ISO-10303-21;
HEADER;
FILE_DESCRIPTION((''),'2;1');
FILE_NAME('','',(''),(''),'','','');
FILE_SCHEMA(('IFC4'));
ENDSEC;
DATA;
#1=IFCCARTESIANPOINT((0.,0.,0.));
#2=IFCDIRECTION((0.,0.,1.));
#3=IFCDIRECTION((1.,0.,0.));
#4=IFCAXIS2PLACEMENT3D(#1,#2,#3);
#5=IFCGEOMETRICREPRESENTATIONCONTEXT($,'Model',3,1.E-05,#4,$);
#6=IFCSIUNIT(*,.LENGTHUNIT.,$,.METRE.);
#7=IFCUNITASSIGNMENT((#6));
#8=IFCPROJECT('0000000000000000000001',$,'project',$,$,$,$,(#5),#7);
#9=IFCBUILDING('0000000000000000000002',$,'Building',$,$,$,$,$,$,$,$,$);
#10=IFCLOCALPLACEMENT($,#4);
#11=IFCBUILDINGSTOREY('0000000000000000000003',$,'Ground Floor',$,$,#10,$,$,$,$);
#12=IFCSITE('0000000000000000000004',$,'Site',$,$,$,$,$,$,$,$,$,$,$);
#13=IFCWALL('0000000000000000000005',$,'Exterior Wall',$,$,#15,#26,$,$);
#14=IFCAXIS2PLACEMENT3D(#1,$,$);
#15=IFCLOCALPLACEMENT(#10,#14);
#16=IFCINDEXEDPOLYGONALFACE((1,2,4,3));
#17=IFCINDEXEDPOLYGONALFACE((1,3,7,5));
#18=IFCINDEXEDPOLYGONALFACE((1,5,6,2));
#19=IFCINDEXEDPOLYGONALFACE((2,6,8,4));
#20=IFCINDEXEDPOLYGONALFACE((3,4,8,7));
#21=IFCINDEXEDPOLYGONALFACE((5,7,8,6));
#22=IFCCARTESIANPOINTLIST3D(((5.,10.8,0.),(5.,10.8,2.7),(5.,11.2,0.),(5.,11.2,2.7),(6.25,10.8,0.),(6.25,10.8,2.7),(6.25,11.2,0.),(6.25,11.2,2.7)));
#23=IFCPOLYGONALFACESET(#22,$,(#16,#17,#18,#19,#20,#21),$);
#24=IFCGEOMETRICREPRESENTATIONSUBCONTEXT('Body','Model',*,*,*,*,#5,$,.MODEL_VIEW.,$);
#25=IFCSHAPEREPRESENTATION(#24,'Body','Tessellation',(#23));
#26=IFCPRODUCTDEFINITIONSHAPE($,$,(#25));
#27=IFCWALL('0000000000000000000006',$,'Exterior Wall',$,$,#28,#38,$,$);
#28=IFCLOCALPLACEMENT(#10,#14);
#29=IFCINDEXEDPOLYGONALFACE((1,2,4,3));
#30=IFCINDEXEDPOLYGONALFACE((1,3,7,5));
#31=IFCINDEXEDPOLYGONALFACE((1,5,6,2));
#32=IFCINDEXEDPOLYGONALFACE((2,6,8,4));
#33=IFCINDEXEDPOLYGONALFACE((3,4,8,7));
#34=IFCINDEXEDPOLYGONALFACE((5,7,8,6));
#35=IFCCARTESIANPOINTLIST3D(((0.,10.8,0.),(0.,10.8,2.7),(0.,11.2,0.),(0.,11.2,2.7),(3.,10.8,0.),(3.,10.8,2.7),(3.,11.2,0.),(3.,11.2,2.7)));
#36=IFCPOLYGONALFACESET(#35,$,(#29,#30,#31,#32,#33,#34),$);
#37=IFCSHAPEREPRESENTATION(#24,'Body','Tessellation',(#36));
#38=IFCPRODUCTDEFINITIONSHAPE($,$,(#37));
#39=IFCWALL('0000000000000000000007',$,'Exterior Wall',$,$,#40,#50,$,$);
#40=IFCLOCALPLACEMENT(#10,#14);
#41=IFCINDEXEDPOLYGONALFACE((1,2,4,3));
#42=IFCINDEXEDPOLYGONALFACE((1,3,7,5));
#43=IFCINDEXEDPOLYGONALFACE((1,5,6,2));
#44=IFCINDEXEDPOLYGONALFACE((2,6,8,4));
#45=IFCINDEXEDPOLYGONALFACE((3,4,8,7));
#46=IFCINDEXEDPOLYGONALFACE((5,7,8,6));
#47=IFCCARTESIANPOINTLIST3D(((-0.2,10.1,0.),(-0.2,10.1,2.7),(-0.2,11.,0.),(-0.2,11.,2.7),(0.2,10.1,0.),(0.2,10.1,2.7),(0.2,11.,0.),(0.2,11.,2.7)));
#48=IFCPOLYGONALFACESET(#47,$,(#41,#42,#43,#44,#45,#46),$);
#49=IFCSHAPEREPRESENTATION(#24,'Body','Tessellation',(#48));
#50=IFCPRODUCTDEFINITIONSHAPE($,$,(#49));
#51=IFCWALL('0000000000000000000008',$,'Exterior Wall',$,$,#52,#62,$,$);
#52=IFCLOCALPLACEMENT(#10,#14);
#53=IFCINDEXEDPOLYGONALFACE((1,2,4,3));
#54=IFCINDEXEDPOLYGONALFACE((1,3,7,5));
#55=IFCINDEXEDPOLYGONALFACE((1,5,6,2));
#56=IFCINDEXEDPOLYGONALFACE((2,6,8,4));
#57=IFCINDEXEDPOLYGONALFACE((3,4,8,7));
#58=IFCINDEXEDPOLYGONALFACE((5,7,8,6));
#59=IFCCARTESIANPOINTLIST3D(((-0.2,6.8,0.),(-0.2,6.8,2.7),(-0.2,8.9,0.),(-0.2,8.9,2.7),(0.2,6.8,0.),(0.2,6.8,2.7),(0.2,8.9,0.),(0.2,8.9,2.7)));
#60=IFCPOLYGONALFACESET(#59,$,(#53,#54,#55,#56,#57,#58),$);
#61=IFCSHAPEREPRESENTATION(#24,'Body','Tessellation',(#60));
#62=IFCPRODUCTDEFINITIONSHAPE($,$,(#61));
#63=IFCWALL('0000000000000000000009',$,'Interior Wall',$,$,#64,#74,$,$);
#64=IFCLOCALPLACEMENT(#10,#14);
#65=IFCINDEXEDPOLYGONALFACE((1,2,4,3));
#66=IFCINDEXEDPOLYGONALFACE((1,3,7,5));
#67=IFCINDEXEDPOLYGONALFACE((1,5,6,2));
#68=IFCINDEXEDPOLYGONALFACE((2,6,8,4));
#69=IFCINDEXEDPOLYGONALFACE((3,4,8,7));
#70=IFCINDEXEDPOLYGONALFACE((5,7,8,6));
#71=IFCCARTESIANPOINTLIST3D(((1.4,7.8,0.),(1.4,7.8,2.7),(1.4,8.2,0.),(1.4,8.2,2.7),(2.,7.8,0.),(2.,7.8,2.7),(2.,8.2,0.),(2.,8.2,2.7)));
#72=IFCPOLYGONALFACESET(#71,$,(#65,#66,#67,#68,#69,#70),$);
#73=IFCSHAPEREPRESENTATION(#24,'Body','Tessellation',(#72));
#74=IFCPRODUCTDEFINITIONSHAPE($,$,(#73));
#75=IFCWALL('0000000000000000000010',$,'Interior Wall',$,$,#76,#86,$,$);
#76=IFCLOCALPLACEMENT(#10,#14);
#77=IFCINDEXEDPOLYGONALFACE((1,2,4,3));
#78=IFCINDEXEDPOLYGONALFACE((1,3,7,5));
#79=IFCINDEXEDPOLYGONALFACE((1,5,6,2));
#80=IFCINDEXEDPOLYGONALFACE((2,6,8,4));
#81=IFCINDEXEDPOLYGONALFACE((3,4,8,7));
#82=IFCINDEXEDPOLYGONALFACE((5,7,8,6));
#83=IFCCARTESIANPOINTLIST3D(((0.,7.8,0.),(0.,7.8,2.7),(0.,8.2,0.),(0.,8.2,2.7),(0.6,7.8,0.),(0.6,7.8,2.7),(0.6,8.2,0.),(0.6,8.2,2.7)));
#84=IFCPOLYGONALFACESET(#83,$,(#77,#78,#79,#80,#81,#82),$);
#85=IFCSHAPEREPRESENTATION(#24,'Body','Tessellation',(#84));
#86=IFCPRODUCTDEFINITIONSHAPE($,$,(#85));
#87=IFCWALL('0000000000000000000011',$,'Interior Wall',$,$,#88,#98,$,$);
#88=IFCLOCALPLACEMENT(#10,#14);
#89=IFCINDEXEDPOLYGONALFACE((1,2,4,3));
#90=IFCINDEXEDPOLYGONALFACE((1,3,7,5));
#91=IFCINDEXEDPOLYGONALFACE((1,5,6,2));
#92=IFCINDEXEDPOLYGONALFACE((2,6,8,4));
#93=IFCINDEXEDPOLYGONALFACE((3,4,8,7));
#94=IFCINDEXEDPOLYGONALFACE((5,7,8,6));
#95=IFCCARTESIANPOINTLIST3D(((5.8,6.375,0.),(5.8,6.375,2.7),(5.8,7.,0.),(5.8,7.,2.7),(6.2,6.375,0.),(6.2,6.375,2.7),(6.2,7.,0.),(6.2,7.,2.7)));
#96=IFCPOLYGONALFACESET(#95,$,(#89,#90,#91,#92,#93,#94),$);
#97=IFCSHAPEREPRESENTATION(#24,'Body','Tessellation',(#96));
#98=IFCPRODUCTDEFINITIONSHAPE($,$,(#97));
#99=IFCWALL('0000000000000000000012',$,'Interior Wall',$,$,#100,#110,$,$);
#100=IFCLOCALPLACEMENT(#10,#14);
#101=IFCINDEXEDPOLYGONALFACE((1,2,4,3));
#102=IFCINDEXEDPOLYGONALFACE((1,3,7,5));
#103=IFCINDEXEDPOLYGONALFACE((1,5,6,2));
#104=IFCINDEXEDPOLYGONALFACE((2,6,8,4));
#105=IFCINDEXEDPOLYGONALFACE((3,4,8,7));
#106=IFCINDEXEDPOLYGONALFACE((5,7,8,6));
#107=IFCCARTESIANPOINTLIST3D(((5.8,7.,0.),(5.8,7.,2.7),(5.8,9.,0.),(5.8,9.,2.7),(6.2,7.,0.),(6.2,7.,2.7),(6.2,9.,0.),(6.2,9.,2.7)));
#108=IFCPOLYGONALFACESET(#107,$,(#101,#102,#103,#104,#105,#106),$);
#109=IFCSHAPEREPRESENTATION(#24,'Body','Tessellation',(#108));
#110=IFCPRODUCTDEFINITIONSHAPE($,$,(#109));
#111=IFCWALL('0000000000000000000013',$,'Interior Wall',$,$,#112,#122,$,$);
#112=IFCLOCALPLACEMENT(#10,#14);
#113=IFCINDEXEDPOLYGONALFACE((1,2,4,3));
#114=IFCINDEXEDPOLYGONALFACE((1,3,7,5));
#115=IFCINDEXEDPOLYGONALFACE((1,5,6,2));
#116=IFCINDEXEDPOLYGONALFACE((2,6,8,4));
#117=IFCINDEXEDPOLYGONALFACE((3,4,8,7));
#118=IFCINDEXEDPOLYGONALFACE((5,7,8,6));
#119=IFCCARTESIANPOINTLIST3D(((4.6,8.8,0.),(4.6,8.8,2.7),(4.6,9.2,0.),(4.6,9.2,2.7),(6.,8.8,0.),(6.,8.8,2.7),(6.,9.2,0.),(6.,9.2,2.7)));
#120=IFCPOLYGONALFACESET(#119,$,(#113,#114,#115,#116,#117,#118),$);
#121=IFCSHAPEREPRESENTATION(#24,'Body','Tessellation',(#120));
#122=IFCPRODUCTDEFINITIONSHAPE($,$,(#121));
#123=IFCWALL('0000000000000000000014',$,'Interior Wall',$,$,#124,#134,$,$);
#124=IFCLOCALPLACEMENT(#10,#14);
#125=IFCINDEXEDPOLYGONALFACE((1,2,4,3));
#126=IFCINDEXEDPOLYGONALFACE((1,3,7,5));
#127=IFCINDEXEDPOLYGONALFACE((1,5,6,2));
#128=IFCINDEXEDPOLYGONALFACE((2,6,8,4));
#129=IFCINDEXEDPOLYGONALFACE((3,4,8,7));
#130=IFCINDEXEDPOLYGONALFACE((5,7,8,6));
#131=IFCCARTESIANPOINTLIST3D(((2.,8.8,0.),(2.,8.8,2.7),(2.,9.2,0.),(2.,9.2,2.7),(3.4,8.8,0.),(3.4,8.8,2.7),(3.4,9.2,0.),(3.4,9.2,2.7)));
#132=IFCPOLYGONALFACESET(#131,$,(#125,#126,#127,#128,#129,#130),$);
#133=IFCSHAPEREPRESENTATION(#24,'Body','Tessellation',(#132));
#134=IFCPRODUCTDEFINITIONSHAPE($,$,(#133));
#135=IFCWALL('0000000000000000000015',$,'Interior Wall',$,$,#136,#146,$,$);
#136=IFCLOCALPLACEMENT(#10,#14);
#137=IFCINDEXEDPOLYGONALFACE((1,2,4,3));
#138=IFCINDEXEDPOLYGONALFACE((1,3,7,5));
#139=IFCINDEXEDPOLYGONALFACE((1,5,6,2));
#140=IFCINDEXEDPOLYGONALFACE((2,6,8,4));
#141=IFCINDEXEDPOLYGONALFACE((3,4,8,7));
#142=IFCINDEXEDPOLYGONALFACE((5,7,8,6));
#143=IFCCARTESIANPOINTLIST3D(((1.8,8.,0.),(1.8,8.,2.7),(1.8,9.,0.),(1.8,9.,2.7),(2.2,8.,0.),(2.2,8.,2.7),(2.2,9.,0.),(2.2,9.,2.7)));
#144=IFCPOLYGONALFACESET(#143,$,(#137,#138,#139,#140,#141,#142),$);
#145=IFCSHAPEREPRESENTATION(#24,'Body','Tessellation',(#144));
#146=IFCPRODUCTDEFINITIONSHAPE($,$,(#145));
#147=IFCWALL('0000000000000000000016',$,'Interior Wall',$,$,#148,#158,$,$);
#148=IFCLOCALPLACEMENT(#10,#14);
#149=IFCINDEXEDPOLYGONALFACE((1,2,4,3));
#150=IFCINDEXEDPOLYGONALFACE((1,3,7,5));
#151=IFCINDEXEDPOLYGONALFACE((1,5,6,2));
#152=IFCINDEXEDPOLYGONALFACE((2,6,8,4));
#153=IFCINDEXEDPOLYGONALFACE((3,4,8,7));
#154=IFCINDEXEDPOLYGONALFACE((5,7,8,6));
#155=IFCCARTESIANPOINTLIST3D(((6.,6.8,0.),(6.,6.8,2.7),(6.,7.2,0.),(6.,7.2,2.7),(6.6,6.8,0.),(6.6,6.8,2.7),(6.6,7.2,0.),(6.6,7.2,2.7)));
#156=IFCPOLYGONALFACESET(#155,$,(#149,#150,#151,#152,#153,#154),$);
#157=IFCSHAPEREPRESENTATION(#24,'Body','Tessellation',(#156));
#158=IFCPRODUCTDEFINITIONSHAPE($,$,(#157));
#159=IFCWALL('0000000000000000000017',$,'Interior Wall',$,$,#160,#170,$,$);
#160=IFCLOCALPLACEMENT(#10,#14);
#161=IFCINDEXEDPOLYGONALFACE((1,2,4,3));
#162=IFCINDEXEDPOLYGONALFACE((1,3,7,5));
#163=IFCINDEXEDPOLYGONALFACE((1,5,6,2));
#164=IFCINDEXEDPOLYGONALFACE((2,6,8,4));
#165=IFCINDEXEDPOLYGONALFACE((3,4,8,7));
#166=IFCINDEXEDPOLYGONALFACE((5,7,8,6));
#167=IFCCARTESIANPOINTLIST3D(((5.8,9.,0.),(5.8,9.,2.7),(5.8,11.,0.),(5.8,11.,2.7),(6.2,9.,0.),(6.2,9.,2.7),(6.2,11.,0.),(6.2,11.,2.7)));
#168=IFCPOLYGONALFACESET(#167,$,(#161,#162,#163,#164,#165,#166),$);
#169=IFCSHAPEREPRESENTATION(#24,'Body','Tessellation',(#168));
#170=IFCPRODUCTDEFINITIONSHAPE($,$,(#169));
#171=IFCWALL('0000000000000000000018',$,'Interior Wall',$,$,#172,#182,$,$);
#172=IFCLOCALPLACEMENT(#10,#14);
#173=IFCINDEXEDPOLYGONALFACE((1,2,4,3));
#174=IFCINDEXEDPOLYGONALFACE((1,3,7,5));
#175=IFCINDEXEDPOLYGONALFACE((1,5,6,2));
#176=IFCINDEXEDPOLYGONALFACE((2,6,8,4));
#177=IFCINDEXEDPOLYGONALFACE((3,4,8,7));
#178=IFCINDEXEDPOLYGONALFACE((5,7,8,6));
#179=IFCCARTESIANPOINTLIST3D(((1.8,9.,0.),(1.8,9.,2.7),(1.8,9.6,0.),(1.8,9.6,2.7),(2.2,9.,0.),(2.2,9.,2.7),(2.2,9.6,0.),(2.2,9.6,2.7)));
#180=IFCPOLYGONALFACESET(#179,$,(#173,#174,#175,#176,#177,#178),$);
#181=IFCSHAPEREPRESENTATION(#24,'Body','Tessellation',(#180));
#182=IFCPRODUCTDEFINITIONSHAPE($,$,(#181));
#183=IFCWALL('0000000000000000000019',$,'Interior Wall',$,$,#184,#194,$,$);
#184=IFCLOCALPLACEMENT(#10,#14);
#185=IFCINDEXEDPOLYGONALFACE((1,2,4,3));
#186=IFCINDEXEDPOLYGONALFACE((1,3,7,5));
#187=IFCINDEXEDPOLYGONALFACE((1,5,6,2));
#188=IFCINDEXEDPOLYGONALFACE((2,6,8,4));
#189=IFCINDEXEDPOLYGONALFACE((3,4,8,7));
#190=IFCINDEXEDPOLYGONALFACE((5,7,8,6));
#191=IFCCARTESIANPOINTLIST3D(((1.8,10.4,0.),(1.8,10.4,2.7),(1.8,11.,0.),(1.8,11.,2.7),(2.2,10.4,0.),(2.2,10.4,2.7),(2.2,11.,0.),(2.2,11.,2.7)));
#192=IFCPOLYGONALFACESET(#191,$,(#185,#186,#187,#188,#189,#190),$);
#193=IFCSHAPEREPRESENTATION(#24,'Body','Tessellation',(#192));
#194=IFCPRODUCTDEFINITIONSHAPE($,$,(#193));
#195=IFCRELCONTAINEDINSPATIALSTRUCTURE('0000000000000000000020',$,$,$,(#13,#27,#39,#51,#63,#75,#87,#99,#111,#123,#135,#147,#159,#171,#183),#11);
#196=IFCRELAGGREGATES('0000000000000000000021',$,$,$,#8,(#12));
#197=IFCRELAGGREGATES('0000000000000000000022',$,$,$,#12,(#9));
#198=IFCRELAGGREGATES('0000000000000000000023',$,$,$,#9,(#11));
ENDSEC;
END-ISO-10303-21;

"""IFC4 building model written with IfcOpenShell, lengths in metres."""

from ifc_helpers import new_model, si_unit, frame, origin_with_axes, place, context, subcontext, project, spatial, indexed_curve, outline, extrude, element, save


model = new_model("IFC4")

# Units and contexts
model_context = context("Model", 3, precision=1e-05, world=origin_with_axes())
body_context = subcontext(model_context, "Body", "Model", "MODEL_VIEW")
ifc_project = project(units=[si_unit("LENGTHUNIT", "METRE")], contexts=[model_context])

# Site, building, storey
site = spatial("IfcSite", under=ifc_project, Name="Site")
building = spatial("IfcBuilding", under=site, Name="Building")
storey_placement = place(None, origin_with_axes())
storey = spatial("IfcBuildingStorey", under=building, at=storey_placement, Name="Ground Floor")

# Walls
wall_1_placement = place(storey_placement, frame((6.25, 11.0, 0.0), z_axis=(0.0, 0.0, 1.0), x_axis=(-1.0, 0.0, 0.0)))
element("IfcWall", 1, at=wall_1_placement, inside=storey, Name="Exterior Wall", context=body_context, shape_type="SweptSolid", body=[
    extrude(outline(indexed_curve([(0.0, 0.0), (0.0, 0.4), (1.25, 0.4), (1.25, 0.0), (0.0, 0.0)], self_intersect=False)), frame((0.0, -0.2, 0.0), z_axis=(0.0, 0.0, 1.0), x_axis=(1.0, 0.0, 0.0)), (0.0, 0.0, 1.0), 2.7),
])
wall_2_placement = place(storey_placement, frame((3.0, 11.0, 0.0), z_axis=(0.0, 0.0, 1.0), x_axis=(-1.0, 0.0, 0.0)))
element("IfcWall", 2, at=wall_2_placement, inside=storey, Name="Exterior Wall", context=body_context, shape_type="SweptSolid", body=[
    extrude(outline(indexed_curve([(0.0, 0.0), (0.0, 0.4), (3.0, 0.4), (3.0, 0.0), (0.0, 0.0)], self_intersect=False)), frame((0.0, -0.2, 0.0), z_axis=(0.0, 0.0, 1.0), x_axis=(1.0, 0.0, 0.0)), (0.0, 0.0, 1.0), 2.7),
])
wall_3_placement = place(storey_placement, frame((0.0, 11.0, 0.0), z_axis=(0.0, 0.0, 1.0), x_axis=(0.0, -1.0, 0.0)))
element("IfcWall", 3, at=wall_3_placement, inside=storey, Name="Exterior Wall", context=body_context, shape_type="SweptSolid", body=[
    extrude(outline(indexed_curve([(0.0, 0.0), (0.0, 0.4), (0.9, 0.4), (0.9, 0.0), (0.0, 0.0)], self_intersect=False)), frame((0.0, -0.2, 0.0), z_axis=(0.0, 0.0, 1.0), x_axis=(1.0, 0.0, 0.0)), (0.0, 0.0, 1.0), 2.7),
])
wall_4_placement = place(storey_placement, frame((0.0, 8.9, 0.0), z_axis=(0.0, 0.0, 1.0), x_axis=(0.0, -1.0, 0.0)))
element("IfcWall", 4, at=wall_4_placement, inside=storey, Name="Exterior Wall", context=body_context, shape_type="SweptSolid", body=[
    extrude(outline(indexed_curve([(0.0, 0.0), (0.0, 0.4), (2.1, 0.4), (2.1, 0.0), (0.0, 0.0)], self_intersect=False)), frame((0.0, -0.2, 0.0), z_axis=(0.0, 0.0, 1.0), x_axis=(1.0, 0.0, 0.0)), (0.0, 0.0, 1.0), 2.7),
])
for number, where, z_axis, x_axis, name in (
    (5, (2.0, 8.0, 0.0), (0.0, 0.0, 1.0), (-1.0, 0.0, 0.0), "Interior Wall"),
    (6, (0.6, 8.0, 0.0), (0.0, 0.0, 1.0), (-1.0, 0.0, 0.0), "Interior Wall"),
):
    element("IfcWall", number, at=place(storey_placement, frame(where, z_axis=z_axis, x_axis=x_axis)), inside=storey, Name=name, context=body_context, shape_type="SweptSolid", body=[
        extrude(outline(indexed_curve([(0.0, 0.0), (0.0, 0.4), (0.6, 0.4), (0.6, 0.0), (0.0, 0.0)], self_intersect=False)), frame((0.0, -0.2, 0.0), z_axis=(0.0, 0.0, 1.0), x_axis=(1.0, 0.0, 0.0)), (0.0, 0.0, 1.0), 2.7),
    ])
wall_5_placement = place(storey_placement, frame((6.0, 6.375, 0.0), z_axis=(0.0, 0.0, 1.0), x_axis=(0.0, 1.0, 0.0)))
element("IfcWall", 7, at=wall_5_placement, inside=storey, Name="Interior Wall", context=body_context, shape_type="SweptSolid", body=[
    extrude(outline(indexed_curve([(0.0, 0.0), (0.0, 0.4), (0.625, 0.4), (0.625, 0.0), (0.0, 0.0)], self_intersect=False)), frame((0.0, -0.2, 0.0), z_axis=(0.0, 0.0, 1.0), x_axis=(1.0, 0.0, 0.0)), (0.0, 0.0, 1.0), 2.7),
])
wall_6_placement = place(storey_placement, frame((6.0, 7.0, 0.0), z_axis=(0.0, 0.0, 1.0), x_axis=(0.0, 1.0, 0.0)))
element("IfcWall", 8, at=wall_6_placement, inside=storey, Name="Interior Wall", context=body_context, shape_type="SweptSolid", body=[
    extrude(outline(indexed_curve([(0.0, 0.0), (0.0, 0.4), (2.0, 0.4), (2.0, 0.0), (0.0, 0.0)], self_intersect=False)), frame((0.0, -0.2, 0.0), z_axis=(0.0, 0.0, 1.0), x_axis=(1.0, 0.0, 0.0)), (0.0, 0.0, 1.0), 2.7),
])
wall_7_placement = place(storey_placement, frame((6.0, 9.0, 0.0), z_axis=(0.0, 0.0, 1.0), x_axis=(-1.0, 0.0, 0.0)))
element("IfcWall", 9, at=wall_7_placement, inside=storey, Name="Interior Wall", context=body_context, shape_type="SweptSolid", body=[
    extrude(outline(indexed_curve([(0.0, 0.0), (0.0, 0.4), (1.4, 0.4), (1.4, 0.0), (0.0, 0.0)], self_intersect=False)), frame((0.0, -0.2, 0.0), z_axis=(0.0, 0.0, 1.0), x_axis=(1.0, 0.0, 0.0)), (0.0, 0.0, 1.0), 2.7),
])
wall_8_placement = place(storey_placement, frame((3.4, 9.0, 0.0), z_axis=(0.0, 0.0, 1.0), x_axis=(-1.0, 0.0, 0.0)))
element("IfcWall", 10, at=wall_8_placement, inside=storey, Name="Interior Wall", context=body_context, shape_type="SweptSolid", body=[
    extrude(outline(indexed_curve([(0.0, 0.0), (0.0, 0.4), (1.4, 0.4), (1.4, 0.0), (0.0, 0.0)], self_intersect=False)), frame((0.0, -0.2, 0.0), z_axis=(0.0, 0.0, 1.0), x_axis=(1.0, 0.0, 0.0)), (0.0, 0.0, 1.0), 2.7),
])
wall_9_placement = place(storey_placement, frame((2.0, 9.0, 0.0), z_axis=(0.0, 0.0, 1.0), x_axis=(0.0, -1.0, 0.0)))
element("IfcWall", 11, at=wall_9_placement, inside=storey, Name="Interior Wall", context=body_context, shape_type="SweptSolid", body=[
    extrude(outline(indexed_curve([(0.0, 0.0), (0.0, 0.4), (1.0, 0.4), (1.0, 0.0), (0.0, 0.0)], self_intersect=False)), frame((0.0, -0.2, 0.0), z_axis=(0.0, 0.0, 1.0), x_axis=(1.0, 0.0, 0.0)), (0.0, 0.0, 1.0), 2.7),
])
wall_10_placement = place(storey_placement, frame((6.6, 7.0, 0.0), z_axis=(0.0, 0.0, 1.0), x_axis=(-1.0, 0.0, 0.0)))
element("IfcWall", 12, at=wall_10_placement, inside=storey, Name="Interior Wall", context=body_context, shape_type="SweptSolid", body=[
    extrude(outline(indexed_curve([(0.0, 0.0), (0.0, 0.4), (0.6, 0.4), (0.6, 0.0), (0.0, 0.0)], self_intersect=False)), frame((0.0, -0.2, 0.0), z_axis=(0.0, 0.0, 1.0), x_axis=(1.0, 0.0, 0.0)), (0.0, 0.0, 1.0), 2.7),
])
wall_11_placement = place(storey_placement, frame((6.0, 11.0, 0.0), z_axis=(0.0, 0.0, 1.0), x_axis=(0.0, -1.0, 0.0)))
element("IfcWall", 13, at=wall_11_placement, inside=storey, Name="Interior Wall", context=body_context, shape_type="SweptSolid", body=[
    extrude(outline(indexed_curve([(0.0, 0.0), (0.0, 0.4), (2.0, 0.4), (2.0, 0.0), (0.0, 0.0)], self_intersect=False)), frame((0.0, -0.2, 0.0), z_axis=(0.0, 0.0, 1.0), x_axis=(1.0, 0.0, 0.0)), (0.0, 0.0, 1.0), 2.7),
])
for number, where, z_axis, x_axis, name in (
    (14, (2.0, 9.0, 0.0), (0.0, 0.0, 1.0), (0.0, 1.0, 0.0), "Interior Wall"),
    (15, (2.0, 10.4, 0.0), (0.0, 0.0, 1.0), (0.0, 1.0, 0.0), "Interior Wall"),
):
    element("IfcWall", number, at=place(storey_placement, frame(where, z_axis=z_axis, x_axis=x_axis)), inside=storey, Name=name, context=body_context, shape_type="SweptSolid", body=[
        extrude(outline(indexed_curve([(0.0, 0.0), (0.0, 0.4), (0.6, 0.4), (0.6, 0.0), (0.0, 0.0)], self_intersect=False)), frame((0.0, -0.2, 0.0), z_axis=(0.0, 0.0, 1.0), x_axis=(1.0, 0.0, 0.0)), (0.0, 0.0, 1.0), 2.7),
    ])

save(model, "model.ifc")
